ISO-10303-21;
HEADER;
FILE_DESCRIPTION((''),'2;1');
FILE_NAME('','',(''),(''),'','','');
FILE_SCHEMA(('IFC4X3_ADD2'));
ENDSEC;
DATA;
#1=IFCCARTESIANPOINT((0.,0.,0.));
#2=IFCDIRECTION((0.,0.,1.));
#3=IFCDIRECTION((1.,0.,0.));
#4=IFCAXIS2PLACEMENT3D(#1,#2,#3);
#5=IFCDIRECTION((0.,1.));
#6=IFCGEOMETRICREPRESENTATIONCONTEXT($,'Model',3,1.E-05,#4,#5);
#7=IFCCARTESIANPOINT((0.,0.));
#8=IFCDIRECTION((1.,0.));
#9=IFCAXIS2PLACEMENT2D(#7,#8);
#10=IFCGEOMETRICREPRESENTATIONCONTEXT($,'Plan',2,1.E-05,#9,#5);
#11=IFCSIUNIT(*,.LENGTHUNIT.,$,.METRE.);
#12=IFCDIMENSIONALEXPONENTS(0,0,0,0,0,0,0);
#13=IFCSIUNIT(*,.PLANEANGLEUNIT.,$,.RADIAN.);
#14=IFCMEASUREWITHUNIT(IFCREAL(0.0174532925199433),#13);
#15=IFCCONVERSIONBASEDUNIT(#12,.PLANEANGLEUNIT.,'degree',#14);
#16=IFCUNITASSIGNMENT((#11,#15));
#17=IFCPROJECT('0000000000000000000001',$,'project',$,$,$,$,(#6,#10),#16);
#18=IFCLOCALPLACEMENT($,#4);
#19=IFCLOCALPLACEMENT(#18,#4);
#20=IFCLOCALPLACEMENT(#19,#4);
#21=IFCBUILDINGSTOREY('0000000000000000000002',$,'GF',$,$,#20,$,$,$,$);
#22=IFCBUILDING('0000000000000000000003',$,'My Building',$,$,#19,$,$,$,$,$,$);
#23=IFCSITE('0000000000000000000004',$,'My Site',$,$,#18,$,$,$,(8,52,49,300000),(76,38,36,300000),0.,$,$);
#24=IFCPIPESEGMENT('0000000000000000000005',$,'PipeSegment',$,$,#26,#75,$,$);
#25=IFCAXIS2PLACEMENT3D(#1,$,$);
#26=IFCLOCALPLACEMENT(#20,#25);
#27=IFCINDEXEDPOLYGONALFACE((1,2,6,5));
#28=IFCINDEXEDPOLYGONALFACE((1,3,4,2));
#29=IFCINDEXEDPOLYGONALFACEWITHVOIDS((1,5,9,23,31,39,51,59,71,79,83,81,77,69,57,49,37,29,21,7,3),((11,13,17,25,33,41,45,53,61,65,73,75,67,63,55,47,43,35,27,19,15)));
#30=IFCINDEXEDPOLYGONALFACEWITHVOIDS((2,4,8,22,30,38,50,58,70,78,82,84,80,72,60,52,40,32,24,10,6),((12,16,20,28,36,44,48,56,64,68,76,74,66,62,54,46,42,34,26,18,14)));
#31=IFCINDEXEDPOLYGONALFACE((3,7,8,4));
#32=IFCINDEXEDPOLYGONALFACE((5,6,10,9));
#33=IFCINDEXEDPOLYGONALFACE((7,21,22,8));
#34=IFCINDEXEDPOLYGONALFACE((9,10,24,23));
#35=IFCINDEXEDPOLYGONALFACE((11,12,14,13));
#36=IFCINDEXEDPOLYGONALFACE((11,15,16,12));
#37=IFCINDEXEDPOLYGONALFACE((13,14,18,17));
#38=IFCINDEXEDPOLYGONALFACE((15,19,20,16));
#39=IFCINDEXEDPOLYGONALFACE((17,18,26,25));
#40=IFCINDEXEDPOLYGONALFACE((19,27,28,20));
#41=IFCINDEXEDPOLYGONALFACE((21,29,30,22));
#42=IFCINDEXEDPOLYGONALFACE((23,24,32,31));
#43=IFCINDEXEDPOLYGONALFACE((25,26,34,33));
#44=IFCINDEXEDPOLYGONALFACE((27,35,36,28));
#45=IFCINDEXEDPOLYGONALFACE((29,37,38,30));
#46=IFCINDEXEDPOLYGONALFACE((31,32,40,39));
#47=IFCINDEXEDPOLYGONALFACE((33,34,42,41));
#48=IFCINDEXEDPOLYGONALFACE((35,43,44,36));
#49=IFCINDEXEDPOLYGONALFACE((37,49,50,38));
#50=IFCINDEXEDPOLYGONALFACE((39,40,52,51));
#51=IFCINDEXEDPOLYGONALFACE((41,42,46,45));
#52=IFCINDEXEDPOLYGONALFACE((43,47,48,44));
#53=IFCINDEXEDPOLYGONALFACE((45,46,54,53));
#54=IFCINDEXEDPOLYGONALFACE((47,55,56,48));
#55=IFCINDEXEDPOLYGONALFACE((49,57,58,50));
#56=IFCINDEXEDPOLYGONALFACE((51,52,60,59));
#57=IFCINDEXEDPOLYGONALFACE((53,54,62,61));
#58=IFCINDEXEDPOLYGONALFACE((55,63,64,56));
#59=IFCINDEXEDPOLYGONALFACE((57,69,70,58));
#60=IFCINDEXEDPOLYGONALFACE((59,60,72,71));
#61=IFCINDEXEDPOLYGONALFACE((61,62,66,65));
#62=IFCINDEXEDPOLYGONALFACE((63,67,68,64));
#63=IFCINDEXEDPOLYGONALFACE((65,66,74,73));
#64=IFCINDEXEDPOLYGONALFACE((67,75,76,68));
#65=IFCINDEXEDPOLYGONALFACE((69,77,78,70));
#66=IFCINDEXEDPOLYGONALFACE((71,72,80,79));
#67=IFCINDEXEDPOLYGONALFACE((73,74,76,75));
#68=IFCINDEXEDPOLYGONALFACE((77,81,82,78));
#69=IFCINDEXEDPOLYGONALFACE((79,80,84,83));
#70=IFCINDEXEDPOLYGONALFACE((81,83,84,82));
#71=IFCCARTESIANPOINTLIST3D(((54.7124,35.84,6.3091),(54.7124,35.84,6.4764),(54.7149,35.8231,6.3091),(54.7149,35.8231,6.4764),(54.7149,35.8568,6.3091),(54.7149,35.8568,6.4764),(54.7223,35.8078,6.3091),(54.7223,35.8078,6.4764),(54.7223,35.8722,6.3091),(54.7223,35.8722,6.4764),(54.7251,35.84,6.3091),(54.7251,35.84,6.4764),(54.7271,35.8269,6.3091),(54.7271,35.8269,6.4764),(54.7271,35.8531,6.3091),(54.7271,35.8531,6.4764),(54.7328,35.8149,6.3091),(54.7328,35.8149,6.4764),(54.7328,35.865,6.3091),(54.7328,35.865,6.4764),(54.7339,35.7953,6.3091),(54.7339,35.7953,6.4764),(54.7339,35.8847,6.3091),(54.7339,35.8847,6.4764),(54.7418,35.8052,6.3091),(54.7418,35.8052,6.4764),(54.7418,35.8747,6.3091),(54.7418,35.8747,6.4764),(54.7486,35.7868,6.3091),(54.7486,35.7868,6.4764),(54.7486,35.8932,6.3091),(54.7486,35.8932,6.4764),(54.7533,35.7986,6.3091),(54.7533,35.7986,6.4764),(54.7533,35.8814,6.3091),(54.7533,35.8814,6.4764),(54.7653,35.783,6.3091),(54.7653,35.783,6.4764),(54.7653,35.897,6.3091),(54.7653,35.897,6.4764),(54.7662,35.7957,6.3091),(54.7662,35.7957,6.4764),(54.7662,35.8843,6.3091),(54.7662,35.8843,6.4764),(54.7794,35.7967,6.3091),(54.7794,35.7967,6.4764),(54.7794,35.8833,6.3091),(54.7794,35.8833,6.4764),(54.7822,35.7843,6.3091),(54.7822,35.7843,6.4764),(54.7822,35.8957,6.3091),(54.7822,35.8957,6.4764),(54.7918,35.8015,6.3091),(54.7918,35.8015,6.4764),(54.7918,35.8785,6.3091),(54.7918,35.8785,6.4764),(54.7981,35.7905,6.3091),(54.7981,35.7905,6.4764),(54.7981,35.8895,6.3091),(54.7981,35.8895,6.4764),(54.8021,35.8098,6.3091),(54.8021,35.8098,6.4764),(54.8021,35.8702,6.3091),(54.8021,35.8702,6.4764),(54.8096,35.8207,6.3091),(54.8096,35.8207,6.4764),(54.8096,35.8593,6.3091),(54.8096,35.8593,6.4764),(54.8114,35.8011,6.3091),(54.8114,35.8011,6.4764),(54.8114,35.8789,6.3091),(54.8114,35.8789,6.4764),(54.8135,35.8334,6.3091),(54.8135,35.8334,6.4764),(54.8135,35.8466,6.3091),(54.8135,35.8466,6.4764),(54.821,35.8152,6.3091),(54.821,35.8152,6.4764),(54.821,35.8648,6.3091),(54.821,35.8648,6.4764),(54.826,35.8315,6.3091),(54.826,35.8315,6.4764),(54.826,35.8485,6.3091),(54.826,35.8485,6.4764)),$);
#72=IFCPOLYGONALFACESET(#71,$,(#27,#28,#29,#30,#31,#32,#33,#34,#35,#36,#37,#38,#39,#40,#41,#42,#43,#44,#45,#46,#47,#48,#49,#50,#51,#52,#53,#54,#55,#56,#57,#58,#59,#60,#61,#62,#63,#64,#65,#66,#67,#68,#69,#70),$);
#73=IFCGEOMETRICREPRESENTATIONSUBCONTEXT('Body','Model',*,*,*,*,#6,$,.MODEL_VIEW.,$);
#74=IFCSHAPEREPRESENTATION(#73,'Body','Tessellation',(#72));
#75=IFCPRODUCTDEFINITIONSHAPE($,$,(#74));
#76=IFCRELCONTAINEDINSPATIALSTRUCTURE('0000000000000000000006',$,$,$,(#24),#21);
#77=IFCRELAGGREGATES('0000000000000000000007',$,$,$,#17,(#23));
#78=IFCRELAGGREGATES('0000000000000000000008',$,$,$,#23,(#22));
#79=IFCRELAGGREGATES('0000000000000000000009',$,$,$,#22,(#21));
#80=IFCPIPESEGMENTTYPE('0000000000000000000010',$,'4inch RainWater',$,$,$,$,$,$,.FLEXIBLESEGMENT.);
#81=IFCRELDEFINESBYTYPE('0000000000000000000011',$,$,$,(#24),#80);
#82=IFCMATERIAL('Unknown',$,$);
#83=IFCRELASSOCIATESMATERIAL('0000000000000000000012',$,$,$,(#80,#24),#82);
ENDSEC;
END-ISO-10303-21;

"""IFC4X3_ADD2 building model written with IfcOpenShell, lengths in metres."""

from ifc_helpers import new_model, entity, si_unit, converted_unit, direction, frame, origin_with_axes, origin_2d_with_axis, place, context, subcontext, project, spatial, hollow_circle, extrude, material, material_profile, profile_set, profile_usage, type_object, element, save


model = new_model("IFC4X3_ADD2")

# Units and contexts
model_context = context("Model", 3, precision=1e-05, world=origin_with_axes(), true_north=direction((0.0, 1.0)))
plan_context = context("Plan", 2, precision=1e-05, world=origin_2d_with_axis(), true_north=direction((0.0, 1.0)))
body_context_1 = subcontext(model_context, "Body", "Model", "MODEL_VIEW")
ifc_project = project(units=[si_unit("LENGTHUNIT", "METRE"), converted_unit("PLANEANGLEUNIT", "degree", entity("IfcReal", 0.0174532925199433), si_unit("PLANEANGLEUNIT", "RADIAN"), dimensions=[0, 0, 0, 0, 0, 0, 0])], contexts=[model_context, plan_context])

# Site, building, storey
site_placement = place(None, origin_with_axes())
site = spatial("IfcSite", under=ifc_project, at=site_placement, Name="My Site", RefLatitude=(8, 52, 49, 300000), RefLongitude=(76, 38, 36, 300000), RefElevation=0.0)
building_placement = place(site_placement, origin_with_axes())
building = spatial("IfcBuilding", under=site, at=building_placement, Name="My Building")
storey_placement = place(building_placement, origin_with_axes())
storey = spatial("IfcBuildingStorey", under=building, at=storey_placement, Name="GF")

# Shared definitions
ifc_material_1 = material(Name="Unknown")

# Pipe segment
ifc_material_profile_1 = material_profile(ifc_material_1, hollow_circle(Radius=0.0571, WallThickness=0.0127))
ifc_profile_set_1 = profile_set([ifc_material_profile_1], Name="rainwater")
pipe_segment_type = type_object("IfcPipeSegmentType", Name="4inch RainWater", PredefinedType="FLEXIBLESEGMENT", material=ifc_profile_set_1)
ifc_profile_usage_1 = profile_usage(ifc_profile_set_1, cardinal=5)
pipe_segment_1_placement = place(storey_placement, frame((54.7695, 35.84, 6.4764), z_axis=(0.0, 0.0, -1.0), x_axis=(-1.0, 0.0, 0.0)))
element("IfcPipeSegment", 1, at=pipe_segment_1_placement, inside=storey, type_object=pipe_segment_type, material=ifc_profile_usage_1, Name="PipeSegment", context=body_context_1, shape_type="SweptSolid", body=[
    extrude(hollow_circle(Radius=0.0571, WallThickness=0.0127), origin_with_axes(), (0.0, 0.0, 1.0), 0.1673),
])

save(model, "model.ifc")
